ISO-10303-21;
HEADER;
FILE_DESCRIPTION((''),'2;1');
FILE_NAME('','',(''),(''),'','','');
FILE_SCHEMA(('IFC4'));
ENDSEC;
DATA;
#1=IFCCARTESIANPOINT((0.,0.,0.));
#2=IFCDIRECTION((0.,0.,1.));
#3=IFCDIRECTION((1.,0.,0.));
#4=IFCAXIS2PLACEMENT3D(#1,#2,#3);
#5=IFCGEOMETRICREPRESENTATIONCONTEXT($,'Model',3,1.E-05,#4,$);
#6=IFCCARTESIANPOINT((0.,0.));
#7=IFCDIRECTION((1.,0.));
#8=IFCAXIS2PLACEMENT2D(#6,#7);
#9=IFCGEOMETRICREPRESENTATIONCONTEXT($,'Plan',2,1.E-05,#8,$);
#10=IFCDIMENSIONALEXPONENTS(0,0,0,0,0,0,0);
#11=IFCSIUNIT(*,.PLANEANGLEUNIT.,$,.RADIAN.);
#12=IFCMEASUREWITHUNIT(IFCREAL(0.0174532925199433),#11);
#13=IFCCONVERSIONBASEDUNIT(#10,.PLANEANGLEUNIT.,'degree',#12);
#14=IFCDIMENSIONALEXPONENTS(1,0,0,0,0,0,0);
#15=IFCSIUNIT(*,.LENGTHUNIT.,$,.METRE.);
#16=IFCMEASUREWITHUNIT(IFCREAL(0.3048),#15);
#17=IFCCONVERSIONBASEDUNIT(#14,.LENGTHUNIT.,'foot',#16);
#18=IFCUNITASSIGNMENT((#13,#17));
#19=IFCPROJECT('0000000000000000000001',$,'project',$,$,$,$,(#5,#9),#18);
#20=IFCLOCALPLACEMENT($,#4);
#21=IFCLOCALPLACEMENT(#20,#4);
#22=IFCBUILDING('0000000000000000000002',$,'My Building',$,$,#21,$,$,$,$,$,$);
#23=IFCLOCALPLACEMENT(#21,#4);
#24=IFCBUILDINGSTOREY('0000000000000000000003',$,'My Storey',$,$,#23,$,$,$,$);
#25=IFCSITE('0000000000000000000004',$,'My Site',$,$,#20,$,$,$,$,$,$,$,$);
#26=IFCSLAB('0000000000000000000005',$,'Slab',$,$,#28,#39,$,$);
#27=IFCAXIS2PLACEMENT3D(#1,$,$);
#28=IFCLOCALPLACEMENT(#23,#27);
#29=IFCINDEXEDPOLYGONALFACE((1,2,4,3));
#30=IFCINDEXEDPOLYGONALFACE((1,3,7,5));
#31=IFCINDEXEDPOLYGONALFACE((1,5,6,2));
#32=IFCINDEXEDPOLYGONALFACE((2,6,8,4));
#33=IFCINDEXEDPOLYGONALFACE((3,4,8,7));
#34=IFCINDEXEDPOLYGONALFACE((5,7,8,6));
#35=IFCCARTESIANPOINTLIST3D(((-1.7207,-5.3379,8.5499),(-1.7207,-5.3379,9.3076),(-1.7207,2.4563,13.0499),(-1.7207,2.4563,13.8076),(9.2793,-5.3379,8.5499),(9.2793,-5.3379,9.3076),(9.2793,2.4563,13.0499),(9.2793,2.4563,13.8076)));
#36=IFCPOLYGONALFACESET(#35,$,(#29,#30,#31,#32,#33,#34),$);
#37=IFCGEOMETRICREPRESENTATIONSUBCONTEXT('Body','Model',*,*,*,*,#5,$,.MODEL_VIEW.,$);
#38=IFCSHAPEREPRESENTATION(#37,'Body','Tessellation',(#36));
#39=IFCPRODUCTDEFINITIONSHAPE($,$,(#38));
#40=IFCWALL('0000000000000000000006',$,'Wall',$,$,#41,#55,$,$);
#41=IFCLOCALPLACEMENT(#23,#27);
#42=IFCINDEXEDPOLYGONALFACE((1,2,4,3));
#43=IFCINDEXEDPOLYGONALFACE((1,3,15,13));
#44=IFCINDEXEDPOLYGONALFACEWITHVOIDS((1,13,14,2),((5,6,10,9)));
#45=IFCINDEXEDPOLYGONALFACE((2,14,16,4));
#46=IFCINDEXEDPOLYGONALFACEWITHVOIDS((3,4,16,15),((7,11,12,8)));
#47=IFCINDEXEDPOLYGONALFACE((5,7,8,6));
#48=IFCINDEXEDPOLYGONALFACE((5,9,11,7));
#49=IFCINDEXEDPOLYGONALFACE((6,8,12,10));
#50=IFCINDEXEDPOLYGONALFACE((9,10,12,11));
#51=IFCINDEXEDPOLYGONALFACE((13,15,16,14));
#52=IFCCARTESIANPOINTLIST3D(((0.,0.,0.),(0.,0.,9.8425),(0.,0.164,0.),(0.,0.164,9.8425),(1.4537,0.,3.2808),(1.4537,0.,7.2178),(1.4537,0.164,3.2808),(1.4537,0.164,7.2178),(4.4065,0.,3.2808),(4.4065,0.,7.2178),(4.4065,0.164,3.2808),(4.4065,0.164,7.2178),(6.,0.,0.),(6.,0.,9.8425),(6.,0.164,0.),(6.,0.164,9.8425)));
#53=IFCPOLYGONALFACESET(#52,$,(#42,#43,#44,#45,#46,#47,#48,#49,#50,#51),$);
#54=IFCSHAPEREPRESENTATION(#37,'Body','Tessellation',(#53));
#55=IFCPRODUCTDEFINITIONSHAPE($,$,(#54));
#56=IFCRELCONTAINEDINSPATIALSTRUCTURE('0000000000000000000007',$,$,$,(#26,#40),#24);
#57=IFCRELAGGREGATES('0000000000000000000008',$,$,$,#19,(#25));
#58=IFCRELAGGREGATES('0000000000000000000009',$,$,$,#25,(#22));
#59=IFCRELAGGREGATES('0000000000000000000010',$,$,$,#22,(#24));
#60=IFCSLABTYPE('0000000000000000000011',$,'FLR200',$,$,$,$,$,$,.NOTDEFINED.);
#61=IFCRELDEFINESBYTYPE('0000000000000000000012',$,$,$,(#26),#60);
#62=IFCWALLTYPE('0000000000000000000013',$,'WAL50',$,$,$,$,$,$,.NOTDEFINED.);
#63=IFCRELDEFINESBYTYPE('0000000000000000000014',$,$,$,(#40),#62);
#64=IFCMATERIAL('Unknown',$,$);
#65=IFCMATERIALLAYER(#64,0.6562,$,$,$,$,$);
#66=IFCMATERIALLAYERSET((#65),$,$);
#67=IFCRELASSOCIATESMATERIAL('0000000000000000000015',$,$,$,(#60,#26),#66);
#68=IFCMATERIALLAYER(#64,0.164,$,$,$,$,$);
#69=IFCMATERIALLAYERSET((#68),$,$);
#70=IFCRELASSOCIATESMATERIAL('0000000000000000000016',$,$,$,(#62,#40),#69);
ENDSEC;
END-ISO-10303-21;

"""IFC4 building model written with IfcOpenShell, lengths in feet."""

from ifc_helpers import new_model, entity, si_unit, converted_unit, frame, origin_with_axes, origin_2d_with_axis, place, context, subcontext, project, spatial, line, indexed_curve, outline, extrude, source, transform, mapped, material, layer, layer_set, layer_usage, type_object, element, save


model = new_model("IFC4")

# Units and contexts
model_context = context("Model", 3, precision=1e-05, world=origin_with_axes())
plan_context = context("Plan", 2, precision=1e-05, world=origin_2d_with_axis())
body_context = subcontext(model_context, "Body", "Model", "MODEL_VIEW")
ifc_project = project(units=[converted_unit("PLANEANGLEUNIT", "degree", entity("IfcReal", 0.0174532925199433), si_unit("PLANEANGLEUNIT", "RADIAN"), dimensions=[0, 0, 0, 0, 0, 0, 0]), converted_unit("LENGTHUNIT", "foot", entity("IfcReal", 0.3048), si_unit("LENGTHUNIT", "METRE"), dimensions=[1, 0, 0, 0, 0, 0, 0])], contexts=[model_context, plan_context])

# Site, building, storey
site_placement = place(None, origin_with_axes())
site = spatial("IfcSite", under=ifc_project, at=site_placement, Name="My Site")
building_placement = place(site_placement, origin_with_axes())
building = spatial("IfcBuilding", under=site, at=building_placement, Name="My Building")
storey_placement = place(building_placement, origin_with_axes())
storey = spatial("IfcBuildingStorey", under=building, at=storey_placement, Name="My Storey")

# Slab
ifc_material = material(Name="Unknown")
ifc_layer_1 = layer(ifc_material, 0.6562)
ifc_layer_set_1 = layer_set([ifc_layer_1])
ifc_layer_usage_1 = layer_usage(ifc_layer_set_1, "AXIS3", "POSITIVE", 0.0)
slab_type = type_object("IfcSlabType", Name="FLR200", PredefinedType="NOTDEFINED", material=ifc_layer_set_1)
slab_placement = place(storey_placement, frame((-1.7207, 2.4563, 13.0499), z_axis=(0.0, -0.5, 0.866025), x_axis=(1.0, 0.0, 0.0)))
element("IfcSlab", 1, at=slab_placement, inside=storey, type_object=slab_type, material=ifc_layer_usage_1, Name="Slab", context=body_context, shape_type="SweptSolid", body=[
    extrude(outline(indexed_curve([(0.0, 0.0), (11.0, 0.0), (11.0, -9.0), (0.0, -9.0), (0.0, 0.0)])), None, (0.0, 0.5, 0.866025), 0.7577),
])

# Wall, opening
ifc_layer_2 = layer(ifc_material, 0.164)
ifc_layer_set_2 = layer_set([ifc_layer_2])
ifc_layer_usage_2 = layer_usage(ifc_layer_set_2, "AXIS2", "POSITIVE", 0.0)
wall_type = type_object("IfcWallType", Name="WAL50", PredefinedType="NOTDEFINED", material=ifc_layer_set_2)
wall_placement = place(storey_placement, origin_with_axes())
wall = element("IfcWall", 2, at=wall_placement, inside=storey, type_object=wall_type, material=ifc_layer_usage_2, Name="Wall", context=body_context, shape_type="SweptSolid", body=[
    extrude(outline(indexed_curve([(0.0, 0.0), (0.0, 0.164), (6.0, 0.164), (6.0, 0.0), (0.0, 0.0)], self_intersect=False)), origin_with_axes(), (0.0, 0.0, 1.0), 9.8425),
])
shared_shape = source(origin_with_axes(), body_context, "Body", "SweptSolid", [
    extrude(outline(indexed_curve([(0.0, 0.0), (2.9528, 0.0), (2.9528, 3.937), (0.0, 3.937)], segments=[line(1, 2, 3, 4, 1)])), frame((0.0, -1.9685, 0.0), z_axis=(0.0, -1.0, 0.0), x_axis=(1.0, 0.0, 0.0)), (0.0, 0.0, -1.0), 3.937),
])
opening_placement = place(wall_placement, frame((1.4537, 0.0, 3.2808), z_axis=(0.0, 0.0, 1.0), x_axis=(1.0, 0.0, 0.0)))
element("IfcOpeningElement", 3, at=opening_placement, cuts=wall, PredefinedType="OPENING", context=body_context, shape_type="MappedRepresentation", body=[
    mapped(shared_shape, transform((0.0, 0.0, 0.0), x_axis=(1.0, 0.0, 0.0), y_axis=(0.0, 1.0, 0.0), z_axis=(0.0, 0.0, 1.0), scale=1.0)),
])

save(model, "model.ifc")
